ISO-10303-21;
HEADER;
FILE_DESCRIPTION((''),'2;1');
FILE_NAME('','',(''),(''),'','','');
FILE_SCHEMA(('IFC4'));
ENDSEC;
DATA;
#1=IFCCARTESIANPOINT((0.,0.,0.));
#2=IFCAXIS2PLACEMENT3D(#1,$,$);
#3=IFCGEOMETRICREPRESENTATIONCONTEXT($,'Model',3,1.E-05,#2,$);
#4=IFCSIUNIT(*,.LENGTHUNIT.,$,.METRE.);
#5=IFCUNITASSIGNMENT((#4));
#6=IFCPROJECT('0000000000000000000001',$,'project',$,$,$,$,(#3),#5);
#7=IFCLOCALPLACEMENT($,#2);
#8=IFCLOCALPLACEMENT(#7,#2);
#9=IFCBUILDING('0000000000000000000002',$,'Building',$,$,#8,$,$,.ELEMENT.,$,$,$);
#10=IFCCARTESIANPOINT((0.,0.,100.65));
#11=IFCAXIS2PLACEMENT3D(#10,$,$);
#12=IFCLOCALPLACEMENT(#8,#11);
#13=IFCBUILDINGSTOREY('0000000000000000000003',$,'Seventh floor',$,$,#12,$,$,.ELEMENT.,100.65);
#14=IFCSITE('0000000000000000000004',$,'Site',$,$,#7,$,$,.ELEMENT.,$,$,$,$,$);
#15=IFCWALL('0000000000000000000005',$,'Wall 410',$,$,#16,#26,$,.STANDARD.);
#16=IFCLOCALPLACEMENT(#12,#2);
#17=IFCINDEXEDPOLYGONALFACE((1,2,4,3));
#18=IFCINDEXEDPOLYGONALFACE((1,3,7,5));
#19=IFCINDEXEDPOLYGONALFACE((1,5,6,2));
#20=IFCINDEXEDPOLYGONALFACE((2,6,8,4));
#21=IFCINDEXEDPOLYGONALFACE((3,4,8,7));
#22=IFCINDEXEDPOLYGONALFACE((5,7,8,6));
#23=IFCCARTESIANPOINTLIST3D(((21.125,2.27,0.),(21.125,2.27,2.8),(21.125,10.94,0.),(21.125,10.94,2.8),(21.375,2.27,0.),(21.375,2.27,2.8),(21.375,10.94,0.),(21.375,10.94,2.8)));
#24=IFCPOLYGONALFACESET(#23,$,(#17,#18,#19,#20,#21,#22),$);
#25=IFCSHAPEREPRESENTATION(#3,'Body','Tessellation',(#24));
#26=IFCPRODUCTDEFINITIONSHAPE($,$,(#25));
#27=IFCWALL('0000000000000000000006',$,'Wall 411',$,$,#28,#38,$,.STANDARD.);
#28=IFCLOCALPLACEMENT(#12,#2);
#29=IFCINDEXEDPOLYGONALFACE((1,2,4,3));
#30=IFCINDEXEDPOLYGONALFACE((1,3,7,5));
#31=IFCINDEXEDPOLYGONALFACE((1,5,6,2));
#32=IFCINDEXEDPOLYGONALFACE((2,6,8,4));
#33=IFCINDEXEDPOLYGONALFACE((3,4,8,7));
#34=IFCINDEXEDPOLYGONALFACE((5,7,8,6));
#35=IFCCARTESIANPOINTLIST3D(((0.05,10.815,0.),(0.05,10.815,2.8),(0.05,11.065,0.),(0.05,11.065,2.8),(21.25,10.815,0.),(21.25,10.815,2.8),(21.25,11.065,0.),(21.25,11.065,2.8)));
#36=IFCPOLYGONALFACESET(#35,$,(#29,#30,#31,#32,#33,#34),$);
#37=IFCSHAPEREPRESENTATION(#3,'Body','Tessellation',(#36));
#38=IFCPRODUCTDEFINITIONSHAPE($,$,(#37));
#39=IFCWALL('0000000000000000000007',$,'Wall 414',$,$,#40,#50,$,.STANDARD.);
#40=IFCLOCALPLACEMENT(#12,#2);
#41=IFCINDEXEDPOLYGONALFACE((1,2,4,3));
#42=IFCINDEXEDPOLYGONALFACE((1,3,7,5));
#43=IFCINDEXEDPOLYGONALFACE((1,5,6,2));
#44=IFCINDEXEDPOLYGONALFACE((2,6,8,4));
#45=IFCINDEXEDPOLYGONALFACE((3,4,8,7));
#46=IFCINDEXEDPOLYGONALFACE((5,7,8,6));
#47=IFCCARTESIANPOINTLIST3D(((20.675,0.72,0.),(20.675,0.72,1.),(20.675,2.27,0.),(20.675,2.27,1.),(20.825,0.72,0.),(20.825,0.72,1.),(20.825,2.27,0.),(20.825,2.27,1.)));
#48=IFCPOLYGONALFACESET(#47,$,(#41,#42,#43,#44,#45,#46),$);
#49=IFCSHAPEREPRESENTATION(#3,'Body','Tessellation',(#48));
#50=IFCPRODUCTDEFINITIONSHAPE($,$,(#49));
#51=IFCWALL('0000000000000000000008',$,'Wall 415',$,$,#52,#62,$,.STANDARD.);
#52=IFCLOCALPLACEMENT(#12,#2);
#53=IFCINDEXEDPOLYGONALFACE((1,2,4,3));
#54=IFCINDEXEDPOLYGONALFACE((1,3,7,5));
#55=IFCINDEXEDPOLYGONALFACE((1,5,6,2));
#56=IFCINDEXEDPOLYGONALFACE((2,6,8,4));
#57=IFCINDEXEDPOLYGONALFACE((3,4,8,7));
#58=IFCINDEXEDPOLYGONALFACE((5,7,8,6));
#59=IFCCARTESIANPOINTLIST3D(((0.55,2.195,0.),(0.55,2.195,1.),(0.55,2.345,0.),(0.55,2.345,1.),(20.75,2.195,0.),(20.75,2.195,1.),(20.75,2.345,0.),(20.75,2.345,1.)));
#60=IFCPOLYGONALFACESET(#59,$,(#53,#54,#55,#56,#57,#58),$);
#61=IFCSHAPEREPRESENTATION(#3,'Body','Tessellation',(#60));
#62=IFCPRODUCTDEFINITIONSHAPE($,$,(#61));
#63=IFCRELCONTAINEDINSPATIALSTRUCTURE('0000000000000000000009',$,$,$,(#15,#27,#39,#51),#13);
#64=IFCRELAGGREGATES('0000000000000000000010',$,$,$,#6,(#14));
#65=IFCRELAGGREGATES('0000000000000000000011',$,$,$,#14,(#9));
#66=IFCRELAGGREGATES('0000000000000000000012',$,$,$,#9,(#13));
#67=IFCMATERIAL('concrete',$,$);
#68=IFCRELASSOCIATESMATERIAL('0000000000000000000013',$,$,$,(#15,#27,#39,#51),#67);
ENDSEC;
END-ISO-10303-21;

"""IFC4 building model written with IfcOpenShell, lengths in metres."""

from ifc_helpers import new_model, si_unit, frame, frame_2d, origin, place, context, project, spatial, rectangle, extrude, material, element, save


model = new_model("IFC4")

# Units and contexts
model_context = context("Model", 3, precision=1e-05, world=origin())
ifc_project = project(units=[si_unit("LENGTHUNIT", "METRE")], contexts=[model_context])

# Site, building, storey
site_placement = place(None, origin())
site = spatial("IfcSite", under=ifc_project, at=site_placement, Name="Site", CompositionType="ELEMENT")
building_placement = place(site_placement, origin())
building = spatial("IfcBuilding", under=site, at=building_placement, Name="Building", CompositionType="ELEMENT")
storey_placement = place(building_placement, frame((0.0, 0.0, 100.65)))
storey = spatial("IfcBuildingStorey", under=building, at=storey_placement, Name="Seventh floor", CompositionType="ELEMENT", Elevation=100.65)

# Walls
ifc_material = material(Name="concrete")
wall_1_placement = place(storey_placement, frame((21.25, 2.27, 0.0), z_axis=(0.0, 0.0, 1.0), x_axis=(0.0, 1.0, 0.0)))
element("IfcWall", 1, at=wall_1_placement, inside=storey, material=ifc_material, Name="Wall 410", PredefinedType="STANDARD", context=model_context, shape_type="SweptSolid", body=[
    extrude(rectangle(XDim=8.67, YDim=0.25, at=frame_2d((4.335, 0.0))), origin(), (0.0, 0.0, 1.0), 2.8),
])
wall_2_placement = place(storey_placement, frame((21.25, 10.94, 0.0), z_axis=(0.0, 0.0, 1.0), x_axis=(-1.0, 0.0, 0.0)))
element("IfcWall", 2, at=wall_2_placement, inside=storey, material=ifc_material, Name="Wall 411", PredefinedType="STANDARD", context=model_context, shape_type="SweptSolid", body=[
    extrude(rectangle(XDim=21.2, YDim=0.25, at=frame_2d((10.6, 0.0))), origin(), (0.0, 0.0, 1.0), 2.8),
])
wall_3_placement = place(storey_placement, frame((20.75, 0.72, 0.0), z_axis=(0.0, 0.0, 1.0), x_axis=(0.0, 1.0, 0.0)))
element("IfcWall", 3, at=wall_3_placement, inside=storey, material=ifc_material, Name="Wall 414", PredefinedType="STANDARD", context=model_context, shape_type="SweptSolid", body=[
    extrude(rectangle(XDim=1.55, YDim=0.15, at=frame_2d((0.775, 0.0))), origin(), (0.0, 0.0, 1.0), 1.0),
])
wall_4_placement = place(storey_placement, frame((20.75, 2.27, 0.0), z_axis=(0.0, 0.0, 1.0), x_axis=(-1.0, 0.0, 0.0)))
element("IfcWall", 4, at=wall_4_placement, inside=storey, material=ifc_material, Name="Wall 415", PredefinedType="STANDARD", context=model_context, shape_type="SweptSolid", body=[
    extrude(rectangle(XDim=20.2, YDim=0.15, at=frame_2d((10.1, 0.0))), origin(), (0.0, 0.0, 1.0), 1.0),
])

save(model, "model.ifc")
